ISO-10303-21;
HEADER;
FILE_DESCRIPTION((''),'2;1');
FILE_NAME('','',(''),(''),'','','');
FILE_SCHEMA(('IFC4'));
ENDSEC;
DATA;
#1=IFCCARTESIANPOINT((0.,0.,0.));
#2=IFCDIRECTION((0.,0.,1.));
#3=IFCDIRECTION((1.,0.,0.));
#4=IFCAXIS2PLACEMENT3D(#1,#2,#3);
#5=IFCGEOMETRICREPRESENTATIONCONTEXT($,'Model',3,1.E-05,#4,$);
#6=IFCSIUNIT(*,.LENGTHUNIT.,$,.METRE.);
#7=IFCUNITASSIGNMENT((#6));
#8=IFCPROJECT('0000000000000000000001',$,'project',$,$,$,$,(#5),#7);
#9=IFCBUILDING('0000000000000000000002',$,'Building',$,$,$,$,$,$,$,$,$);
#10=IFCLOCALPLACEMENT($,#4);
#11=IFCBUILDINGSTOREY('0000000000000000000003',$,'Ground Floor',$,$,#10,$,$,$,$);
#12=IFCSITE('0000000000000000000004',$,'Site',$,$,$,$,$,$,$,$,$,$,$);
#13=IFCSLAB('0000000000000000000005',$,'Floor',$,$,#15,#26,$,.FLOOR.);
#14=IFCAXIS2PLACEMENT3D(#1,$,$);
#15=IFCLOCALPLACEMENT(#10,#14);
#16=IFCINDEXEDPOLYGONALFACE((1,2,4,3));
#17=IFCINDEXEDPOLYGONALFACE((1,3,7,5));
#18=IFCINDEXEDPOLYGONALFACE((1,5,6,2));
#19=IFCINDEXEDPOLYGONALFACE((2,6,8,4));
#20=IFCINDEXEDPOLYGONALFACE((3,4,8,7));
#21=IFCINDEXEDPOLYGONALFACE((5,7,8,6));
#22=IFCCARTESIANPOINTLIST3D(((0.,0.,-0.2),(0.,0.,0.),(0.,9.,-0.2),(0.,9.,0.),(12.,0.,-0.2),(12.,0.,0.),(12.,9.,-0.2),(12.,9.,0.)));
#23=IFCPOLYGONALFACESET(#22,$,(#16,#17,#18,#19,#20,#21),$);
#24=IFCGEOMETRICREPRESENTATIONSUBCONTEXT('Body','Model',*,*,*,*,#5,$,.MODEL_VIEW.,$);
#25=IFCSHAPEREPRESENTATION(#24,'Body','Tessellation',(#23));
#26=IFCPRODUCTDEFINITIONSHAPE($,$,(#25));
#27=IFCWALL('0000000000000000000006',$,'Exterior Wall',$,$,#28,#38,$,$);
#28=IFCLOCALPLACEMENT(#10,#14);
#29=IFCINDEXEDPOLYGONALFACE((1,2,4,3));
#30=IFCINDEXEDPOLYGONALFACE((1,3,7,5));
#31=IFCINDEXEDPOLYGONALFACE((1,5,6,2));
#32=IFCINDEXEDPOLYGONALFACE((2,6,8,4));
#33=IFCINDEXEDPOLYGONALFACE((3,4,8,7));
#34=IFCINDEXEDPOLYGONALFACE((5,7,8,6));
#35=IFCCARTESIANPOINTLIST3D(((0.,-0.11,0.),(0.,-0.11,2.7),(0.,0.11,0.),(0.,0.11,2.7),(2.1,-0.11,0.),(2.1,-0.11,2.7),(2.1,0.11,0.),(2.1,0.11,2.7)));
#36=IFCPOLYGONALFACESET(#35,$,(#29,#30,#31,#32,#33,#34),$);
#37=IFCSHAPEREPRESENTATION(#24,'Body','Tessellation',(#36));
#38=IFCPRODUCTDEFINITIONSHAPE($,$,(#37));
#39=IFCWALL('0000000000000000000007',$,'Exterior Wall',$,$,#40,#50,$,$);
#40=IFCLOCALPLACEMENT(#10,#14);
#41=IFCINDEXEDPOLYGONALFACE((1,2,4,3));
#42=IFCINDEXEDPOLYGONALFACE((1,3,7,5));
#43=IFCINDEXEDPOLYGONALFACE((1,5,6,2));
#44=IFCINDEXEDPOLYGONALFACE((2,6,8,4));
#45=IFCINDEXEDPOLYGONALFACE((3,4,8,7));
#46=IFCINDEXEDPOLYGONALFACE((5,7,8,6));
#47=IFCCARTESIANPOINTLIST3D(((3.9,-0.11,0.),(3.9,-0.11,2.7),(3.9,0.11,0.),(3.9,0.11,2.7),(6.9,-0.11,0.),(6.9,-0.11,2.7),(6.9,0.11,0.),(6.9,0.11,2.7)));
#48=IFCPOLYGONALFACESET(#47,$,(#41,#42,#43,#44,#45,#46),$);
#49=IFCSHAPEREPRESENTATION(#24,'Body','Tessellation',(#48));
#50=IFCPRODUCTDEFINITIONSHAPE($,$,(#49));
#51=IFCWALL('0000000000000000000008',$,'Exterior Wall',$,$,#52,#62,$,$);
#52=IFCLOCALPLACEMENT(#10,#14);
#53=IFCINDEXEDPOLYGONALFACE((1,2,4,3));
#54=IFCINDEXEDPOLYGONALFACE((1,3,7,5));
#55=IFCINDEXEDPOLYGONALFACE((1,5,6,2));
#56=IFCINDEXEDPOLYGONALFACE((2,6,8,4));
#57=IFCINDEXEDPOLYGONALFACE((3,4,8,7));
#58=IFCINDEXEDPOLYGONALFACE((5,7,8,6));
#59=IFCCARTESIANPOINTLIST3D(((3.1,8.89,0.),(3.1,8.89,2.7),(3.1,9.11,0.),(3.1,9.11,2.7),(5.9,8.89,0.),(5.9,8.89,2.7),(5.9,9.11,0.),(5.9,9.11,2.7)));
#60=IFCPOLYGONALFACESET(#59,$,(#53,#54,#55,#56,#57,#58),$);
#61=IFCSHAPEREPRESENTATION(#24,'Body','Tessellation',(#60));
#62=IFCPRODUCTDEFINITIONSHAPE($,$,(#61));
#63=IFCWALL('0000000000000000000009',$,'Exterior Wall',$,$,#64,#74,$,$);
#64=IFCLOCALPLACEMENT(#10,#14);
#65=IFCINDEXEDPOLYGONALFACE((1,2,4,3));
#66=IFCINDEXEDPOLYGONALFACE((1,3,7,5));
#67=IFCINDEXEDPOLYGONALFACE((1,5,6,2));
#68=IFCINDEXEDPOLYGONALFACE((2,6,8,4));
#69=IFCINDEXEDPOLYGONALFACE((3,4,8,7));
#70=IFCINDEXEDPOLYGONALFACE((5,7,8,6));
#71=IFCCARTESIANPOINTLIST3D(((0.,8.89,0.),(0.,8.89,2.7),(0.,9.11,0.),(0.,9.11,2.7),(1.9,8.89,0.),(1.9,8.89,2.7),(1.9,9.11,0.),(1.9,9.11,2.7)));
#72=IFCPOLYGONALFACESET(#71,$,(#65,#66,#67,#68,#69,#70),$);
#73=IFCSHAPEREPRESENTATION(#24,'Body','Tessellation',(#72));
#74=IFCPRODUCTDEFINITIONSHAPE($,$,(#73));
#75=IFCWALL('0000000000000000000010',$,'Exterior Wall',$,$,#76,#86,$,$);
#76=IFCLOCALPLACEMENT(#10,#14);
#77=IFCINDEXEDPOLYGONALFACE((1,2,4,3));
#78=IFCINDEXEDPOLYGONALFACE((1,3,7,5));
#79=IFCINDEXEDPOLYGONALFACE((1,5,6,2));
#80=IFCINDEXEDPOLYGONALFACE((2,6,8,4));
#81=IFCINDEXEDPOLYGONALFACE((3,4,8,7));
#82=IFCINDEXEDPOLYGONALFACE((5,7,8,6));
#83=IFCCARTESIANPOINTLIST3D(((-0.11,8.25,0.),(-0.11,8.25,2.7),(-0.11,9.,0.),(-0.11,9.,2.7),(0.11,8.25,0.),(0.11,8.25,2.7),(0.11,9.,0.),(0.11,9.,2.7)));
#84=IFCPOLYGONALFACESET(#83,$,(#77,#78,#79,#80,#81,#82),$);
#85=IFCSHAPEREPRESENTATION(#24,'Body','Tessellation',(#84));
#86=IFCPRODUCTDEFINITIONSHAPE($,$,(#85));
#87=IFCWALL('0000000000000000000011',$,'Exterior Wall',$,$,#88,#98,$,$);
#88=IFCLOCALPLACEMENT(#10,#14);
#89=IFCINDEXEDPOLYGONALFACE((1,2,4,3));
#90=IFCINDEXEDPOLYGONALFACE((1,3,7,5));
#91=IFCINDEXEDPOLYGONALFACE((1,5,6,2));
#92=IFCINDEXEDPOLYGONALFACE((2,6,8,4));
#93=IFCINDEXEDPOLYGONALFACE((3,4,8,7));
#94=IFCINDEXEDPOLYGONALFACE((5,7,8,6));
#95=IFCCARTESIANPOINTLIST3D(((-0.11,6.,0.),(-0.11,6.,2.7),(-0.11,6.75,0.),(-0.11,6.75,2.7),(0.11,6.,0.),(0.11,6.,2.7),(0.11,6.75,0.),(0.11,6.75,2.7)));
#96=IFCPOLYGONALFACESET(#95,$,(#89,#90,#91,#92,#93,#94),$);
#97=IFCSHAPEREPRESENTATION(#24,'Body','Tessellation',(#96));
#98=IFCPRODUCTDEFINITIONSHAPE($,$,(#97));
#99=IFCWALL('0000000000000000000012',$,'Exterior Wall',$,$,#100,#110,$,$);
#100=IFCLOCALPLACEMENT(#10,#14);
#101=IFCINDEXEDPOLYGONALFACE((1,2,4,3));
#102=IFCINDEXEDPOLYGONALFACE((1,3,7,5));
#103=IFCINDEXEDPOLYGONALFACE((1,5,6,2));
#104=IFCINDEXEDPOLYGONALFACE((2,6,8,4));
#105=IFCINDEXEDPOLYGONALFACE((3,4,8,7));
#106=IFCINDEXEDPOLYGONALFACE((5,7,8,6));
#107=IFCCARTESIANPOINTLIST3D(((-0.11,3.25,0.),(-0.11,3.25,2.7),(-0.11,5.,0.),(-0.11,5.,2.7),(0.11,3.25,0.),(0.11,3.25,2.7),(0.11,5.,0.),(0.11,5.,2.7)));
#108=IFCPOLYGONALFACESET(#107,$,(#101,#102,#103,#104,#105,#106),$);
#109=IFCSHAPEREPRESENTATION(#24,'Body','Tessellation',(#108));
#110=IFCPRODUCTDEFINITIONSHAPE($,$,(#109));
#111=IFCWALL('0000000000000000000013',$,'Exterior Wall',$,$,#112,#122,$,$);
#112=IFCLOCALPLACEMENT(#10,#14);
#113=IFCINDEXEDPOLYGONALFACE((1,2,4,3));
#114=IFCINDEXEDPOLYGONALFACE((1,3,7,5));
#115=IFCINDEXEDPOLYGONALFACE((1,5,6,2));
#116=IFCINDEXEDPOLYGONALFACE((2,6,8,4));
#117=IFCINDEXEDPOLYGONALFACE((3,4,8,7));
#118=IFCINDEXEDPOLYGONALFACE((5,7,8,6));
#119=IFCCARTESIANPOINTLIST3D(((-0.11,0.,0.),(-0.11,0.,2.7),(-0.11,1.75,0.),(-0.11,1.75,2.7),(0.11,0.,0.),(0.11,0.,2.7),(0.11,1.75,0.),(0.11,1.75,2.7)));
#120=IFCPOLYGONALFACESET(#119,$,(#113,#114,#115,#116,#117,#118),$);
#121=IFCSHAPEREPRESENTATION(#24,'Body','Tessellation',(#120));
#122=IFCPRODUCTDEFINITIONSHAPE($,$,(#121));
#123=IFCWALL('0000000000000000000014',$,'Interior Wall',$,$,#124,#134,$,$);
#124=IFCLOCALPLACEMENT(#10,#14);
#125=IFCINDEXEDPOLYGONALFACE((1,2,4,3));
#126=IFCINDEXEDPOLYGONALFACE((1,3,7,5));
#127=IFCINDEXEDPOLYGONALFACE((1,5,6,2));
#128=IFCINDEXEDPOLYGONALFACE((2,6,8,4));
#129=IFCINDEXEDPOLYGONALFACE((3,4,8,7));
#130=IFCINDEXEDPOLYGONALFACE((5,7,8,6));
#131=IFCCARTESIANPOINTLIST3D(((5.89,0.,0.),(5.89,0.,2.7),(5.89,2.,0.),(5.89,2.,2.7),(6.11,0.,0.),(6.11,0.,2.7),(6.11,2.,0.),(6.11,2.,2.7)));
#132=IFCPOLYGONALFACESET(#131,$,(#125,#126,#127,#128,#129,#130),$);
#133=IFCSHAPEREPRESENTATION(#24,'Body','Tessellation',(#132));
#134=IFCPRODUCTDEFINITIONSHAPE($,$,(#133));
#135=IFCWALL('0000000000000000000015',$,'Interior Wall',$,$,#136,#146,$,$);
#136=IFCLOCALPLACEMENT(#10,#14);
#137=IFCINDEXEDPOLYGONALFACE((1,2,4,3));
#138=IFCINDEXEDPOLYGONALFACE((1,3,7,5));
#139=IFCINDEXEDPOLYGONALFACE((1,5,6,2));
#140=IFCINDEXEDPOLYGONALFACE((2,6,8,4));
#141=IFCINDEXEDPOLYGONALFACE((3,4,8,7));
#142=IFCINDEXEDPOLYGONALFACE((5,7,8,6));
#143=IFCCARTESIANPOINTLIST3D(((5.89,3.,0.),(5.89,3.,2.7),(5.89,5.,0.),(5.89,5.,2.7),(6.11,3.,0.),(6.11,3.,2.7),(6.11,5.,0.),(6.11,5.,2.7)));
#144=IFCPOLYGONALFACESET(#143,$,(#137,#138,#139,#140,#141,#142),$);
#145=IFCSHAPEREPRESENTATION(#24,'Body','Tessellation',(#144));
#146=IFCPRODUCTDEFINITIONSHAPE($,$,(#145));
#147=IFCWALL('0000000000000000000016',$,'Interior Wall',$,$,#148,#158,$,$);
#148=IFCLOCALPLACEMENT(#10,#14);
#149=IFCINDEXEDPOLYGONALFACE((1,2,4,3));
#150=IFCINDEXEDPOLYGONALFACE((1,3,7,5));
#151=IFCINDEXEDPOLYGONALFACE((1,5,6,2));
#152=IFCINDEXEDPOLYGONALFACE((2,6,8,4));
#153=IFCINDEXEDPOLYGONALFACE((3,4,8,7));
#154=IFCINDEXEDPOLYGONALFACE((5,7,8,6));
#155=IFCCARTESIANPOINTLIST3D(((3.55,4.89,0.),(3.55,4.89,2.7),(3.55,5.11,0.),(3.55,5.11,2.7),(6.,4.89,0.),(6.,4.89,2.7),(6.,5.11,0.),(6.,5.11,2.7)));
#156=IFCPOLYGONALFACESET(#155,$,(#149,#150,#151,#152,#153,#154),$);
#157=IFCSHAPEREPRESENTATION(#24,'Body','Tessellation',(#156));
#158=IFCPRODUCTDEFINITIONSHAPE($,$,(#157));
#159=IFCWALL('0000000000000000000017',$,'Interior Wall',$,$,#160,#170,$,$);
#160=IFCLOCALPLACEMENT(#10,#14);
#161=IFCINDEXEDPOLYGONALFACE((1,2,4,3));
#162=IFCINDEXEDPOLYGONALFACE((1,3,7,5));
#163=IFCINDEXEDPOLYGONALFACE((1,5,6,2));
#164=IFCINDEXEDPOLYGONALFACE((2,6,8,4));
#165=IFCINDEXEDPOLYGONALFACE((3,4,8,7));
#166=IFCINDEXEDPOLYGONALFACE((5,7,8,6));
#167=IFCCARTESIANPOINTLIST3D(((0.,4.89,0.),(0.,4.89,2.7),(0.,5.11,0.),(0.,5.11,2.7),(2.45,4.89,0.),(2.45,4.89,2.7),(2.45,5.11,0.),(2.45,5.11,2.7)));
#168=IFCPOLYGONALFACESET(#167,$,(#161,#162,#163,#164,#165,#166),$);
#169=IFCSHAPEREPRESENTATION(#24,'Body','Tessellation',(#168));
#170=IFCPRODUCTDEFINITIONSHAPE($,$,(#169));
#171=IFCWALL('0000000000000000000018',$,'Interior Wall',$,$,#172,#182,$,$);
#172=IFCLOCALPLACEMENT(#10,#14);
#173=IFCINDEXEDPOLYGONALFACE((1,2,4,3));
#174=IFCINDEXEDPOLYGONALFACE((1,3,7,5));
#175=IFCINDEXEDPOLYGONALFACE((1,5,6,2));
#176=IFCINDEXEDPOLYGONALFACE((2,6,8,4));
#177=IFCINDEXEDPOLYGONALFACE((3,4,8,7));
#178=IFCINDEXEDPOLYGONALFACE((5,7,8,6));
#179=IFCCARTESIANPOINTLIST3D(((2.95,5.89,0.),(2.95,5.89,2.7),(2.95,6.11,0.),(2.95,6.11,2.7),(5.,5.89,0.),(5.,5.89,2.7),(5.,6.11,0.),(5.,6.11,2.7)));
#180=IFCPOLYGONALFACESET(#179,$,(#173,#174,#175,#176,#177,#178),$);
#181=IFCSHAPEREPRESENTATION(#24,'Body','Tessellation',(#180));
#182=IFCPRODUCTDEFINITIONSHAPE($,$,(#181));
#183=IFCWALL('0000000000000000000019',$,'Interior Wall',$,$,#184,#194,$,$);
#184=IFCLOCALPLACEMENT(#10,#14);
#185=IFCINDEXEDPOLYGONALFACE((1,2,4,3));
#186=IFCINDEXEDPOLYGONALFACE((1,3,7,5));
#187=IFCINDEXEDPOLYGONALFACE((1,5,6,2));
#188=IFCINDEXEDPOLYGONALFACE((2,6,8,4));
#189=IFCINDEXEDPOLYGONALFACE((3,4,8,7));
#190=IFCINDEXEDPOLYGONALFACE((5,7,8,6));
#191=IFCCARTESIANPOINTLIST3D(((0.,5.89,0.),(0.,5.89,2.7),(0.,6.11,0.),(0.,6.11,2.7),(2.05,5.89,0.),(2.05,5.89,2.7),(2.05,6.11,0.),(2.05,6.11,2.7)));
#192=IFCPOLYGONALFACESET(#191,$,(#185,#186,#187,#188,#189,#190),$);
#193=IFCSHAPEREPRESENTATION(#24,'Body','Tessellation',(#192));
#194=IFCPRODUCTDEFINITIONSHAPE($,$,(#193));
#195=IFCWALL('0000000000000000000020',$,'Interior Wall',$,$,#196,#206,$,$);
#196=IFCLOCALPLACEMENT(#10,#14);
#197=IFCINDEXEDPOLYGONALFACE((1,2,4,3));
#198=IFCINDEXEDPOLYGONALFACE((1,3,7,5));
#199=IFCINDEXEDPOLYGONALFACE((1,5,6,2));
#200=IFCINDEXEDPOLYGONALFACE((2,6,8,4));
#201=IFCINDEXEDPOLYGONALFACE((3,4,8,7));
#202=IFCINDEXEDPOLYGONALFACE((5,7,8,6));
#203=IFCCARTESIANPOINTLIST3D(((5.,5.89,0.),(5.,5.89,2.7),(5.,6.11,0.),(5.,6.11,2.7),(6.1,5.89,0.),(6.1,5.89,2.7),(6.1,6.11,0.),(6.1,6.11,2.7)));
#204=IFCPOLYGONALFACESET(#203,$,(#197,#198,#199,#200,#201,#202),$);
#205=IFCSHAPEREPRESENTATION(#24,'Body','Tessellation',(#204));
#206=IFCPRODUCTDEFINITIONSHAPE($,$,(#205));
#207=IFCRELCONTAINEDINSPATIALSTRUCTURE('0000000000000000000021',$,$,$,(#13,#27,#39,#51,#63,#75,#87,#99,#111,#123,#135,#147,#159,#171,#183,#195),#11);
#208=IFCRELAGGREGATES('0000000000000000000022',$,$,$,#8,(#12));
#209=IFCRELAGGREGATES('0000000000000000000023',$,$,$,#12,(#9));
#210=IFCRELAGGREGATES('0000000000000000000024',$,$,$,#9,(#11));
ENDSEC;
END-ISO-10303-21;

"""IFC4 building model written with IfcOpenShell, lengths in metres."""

from ifc_helpers import new_model, si_unit, frame, origin_with_axes, place, context, subcontext, project, spatial, indexed_curve, outline, extrude, element, save


model = new_model("IFC4")

# Units and contexts
model_context = context("Model", 3, precision=1e-05, world=origin_with_axes())
body_context = subcontext(model_context, "Body", "Model", "MODEL_VIEW")
ifc_project = project(units=[si_unit("LENGTHUNIT", "METRE")], contexts=[model_context])

# Site, building, storey
site = spatial("IfcSite", under=ifc_project, Name="Site")
building = spatial("IfcBuilding", under=site, Name="Building")
storey_placement = place(None, origin_with_axes())
storey = spatial("IfcBuildingStorey", under=building, at=storey_placement, Name="Ground Floor")

# Slab
slab_placement = place(storey_placement, frame((0.0, 0.0, -0.2), z_axis=(0.0, 0.0, 1.0), x_axis=(1.0, 0.0, 0.0)))
element("IfcSlab", 1, at=slab_placement, inside=storey, Name="Floor", PredefinedType="FLOOR", context=body_context, shape_type="SweptSolid", body=[
    extrude(outline(indexed_curve([(0.0, 0.0), (12.0, 0.0), (12.0, 9.0), (0.0, 9.0)])), None, (0.0, 0.0, 1.0), 0.2),
])

# Walls
wall_1_placement = place(storey_placement, origin_with_axes())
element("IfcWall", 2, at=wall_1_placement, inside=storey, Name="Exterior Wall", context=body_context, shape_type="SweptSolid", body=[
    extrude(outline(indexed_curve([(0.0, 0.0), (0.0, 0.22), (2.1, 0.22), (2.1, 0.0), (0.0, 0.0)], self_intersect=False)), frame((0.0, -0.11, 0.0), z_axis=(0.0, 0.0, 1.0), x_axis=(1.0, 0.0, 0.0)), (0.0, 0.0, 1.0), 2.7),
])
wall_2_placement = place(storey_placement, frame((3.9, 0.0, 0.0), z_axis=(0.0, 0.0, 1.0), x_axis=(1.0, 0.0, 0.0)))
element("IfcWall", 3, at=wall_2_placement, inside=storey, Name="Exterior Wall", context=body_context, shape_type="SweptSolid", body=[
    extrude(outline(indexed_curve([(0.0, 0.0), (0.0, 0.22), (3.0, 0.22), (3.0, 0.0), (0.0, 0.0)], self_intersect=False)), frame((0.0, -0.11, 0.0), z_axis=(0.0, 0.0, 1.0), x_axis=(1.0, 0.0, 0.0)), (0.0, 0.0, 1.0), 2.7),
])
wall_3_placement = place(storey_placement, frame((5.9, 9.0, 0.0), z_axis=(0.0, 0.0, 1.0), x_axis=(-1.0, 0.0, 0.0)))
element("IfcWall", 4, at=wall_3_placement, inside=storey, Name="Exterior Wall", context=body_context, shape_type="SweptSolid", body=[
    extrude(outline(indexed_curve([(0.0, 0.0), (0.0, 0.22), (2.8, 0.22), (2.8, 0.0), (0.0, 0.0)], self_intersect=False)), frame((0.0, -0.11, 0.0), z_axis=(0.0, 0.0, 1.0), x_axis=(1.0, 0.0, 0.0)), (0.0, 0.0, 1.0), 2.7),
])
wall_4_placement = place(storey_placement, frame((1.9, 9.0, 0.0), z_axis=(0.0, 0.0, 1.0), x_axis=(-1.0, 0.0, 0.0)))
element("IfcWall", 5, at=wall_4_placement, inside=storey, Name="Exterior Wall", context=body_context, shape_type="SweptSolid", body=[
    extrude(outline(indexed_curve([(0.0, 0.0), (0.0, 0.22), (1.9, 0.22), (1.9, 0.0), (0.0, 0.0)], self_intersect=False)), frame((0.0, -0.11, 0.0), z_axis=(0.0, 0.0, 1.0), x_axis=(1.0, 0.0, 0.0)), (0.0, 0.0, 1.0), 2.7),
])
for number, where, z_axis, x_axis, name in (
    (6, (0.0, 9.0, 0.0), (0.0, 0.0, 1.0), (0.0, -1.0, 0.0), "Exterior Wall"),
    (7, (0.0, 6.75, 0.0), (0.0, 0.0, 1.0), (0.0, -1.0, 0.0), "Exterior Wall"),
):
    element("IfcWall", number, at=place(storey_placement, frame(where, z_axis=z_axis, x_axis=x_axis)), inside=storey, Name=name, context=body_context, shape_type="SweptSolid", body=[
        extrude(outline(indexed_curve([(0.0, 0.0), (0.0, 0.22), (0.75, 0.22), (0.75, 0.0), (0.0, 0.0)], self_intersect=False)), frame((0.0, -0.11, 0.0), z_axis=(0.0, 0.0, 1.0), x_axis=(1.0, 0.0, 0.0)), (0.0, 0.0, 1.0), 2.7),
    ])
for number, where, z_axis, x_axis, name in (
    (8, (0.0, 5.0, 0.0), (0.0, 0.0, 1.0), (0.0, -1.0, 0.0), "Exterior Wall"),
    (9, (0.0, 1.75, 0.0), (0.0, 0.0, 1.0), (0.0, -1.0, 0.0), "Exterior Wall"),
):
    element("IfcWall", number, at=place(storey_placement, frame(where, z_axis=z_axis, x_axis=x_axis)), inside=storey, Name=name, context=body_context, shape_type="SweptSolid", body=[
        extrude(outline(indexed_curve([(0.0, 0.0), (0.0, 0.22), (1.75, 0.22), (1.75, 0.0), (0.0, 0.0)], self_intersect=False)), frame((0.0, -0.11, 0.0), z_axis=(0.0, 0.0, 1.0), x_axis=(1.0, 0.0, 0.0)), (0.0, 0.0, 1.0), 2.7),
    ])
for number, where, z_axis, x_axis, name in (
    (10, (6.0, 0.0, 0.0), (0.0, 0.0, 1.0), (0.0, 1.0, 0.0), "Interior Wall"),
    (11, (6.0, 3.0, 0.0), (0.0, 0.0, 1.0), (0.0, 1.0, 0.0), "Interior Wall"),
):
    element("IfcWall", number, at=place(storey_placement, frame(where, z_axis=z_axis, x_axis=x_axis)), inside=storey, Name=name, context=body_context, shape_type="SweptSolid", body=[
        extrude(outline(indexed_curve([(0.0, 0.0), (0.0, 0.22), (2.0, 0.22), (2.0, 0.0), (0.0, 0.0)], self_intersect=False)), frame((0.0, -0.11, 0.0), z_axis=(0.0, 0.0, 1.0), x_axis=(1.0, 0.0, 0.0)), (0.0, 0.0, 1.0), 2.7),
    ])
for number, where, z_axis, x_axis, name in (
    (12, (6.0, 5.0, 0.0), (0.0, 0.0, 1.0), (-1.0, 0.0, 0.0), "Interior Wall"),
    (13, (2.45, 5.0, 0.0), (0.0, 0.0, 1.0), (-1.0, 0.0, 0.0), "Interior Wall"),
):
    element("IfcWall", number, at=place(storey_placement, frame(where, z_axis=z_axis, x_axis=x_axis)), inside=storey, Name=name, context=body_context, shape_type="SweptSolid", body=[
        extrude(outline(indexed_curve([(0.0, 0.0), (0.0, 0.22), (2.45, 0.22), (2.45, 0.0), (0.0, 0.0)], self_intersect=False)), frame((0.0, -0.11, 0.0), z_axis=(0.0, 0.0, 1.0), x_axis=(1.0, 0.0, 0.0)), (0.0, 0.0, 1.0), 2.7),
    ])
for number, where, z_axis, x_axis, name in (
    (14, (5.0, 6.0, 0.0), (0.0, 0.0, 1.0), (-1.0, 0.0, 0.0), "Interior Wall"),
    (15, (2.05, 6.0, 0.0), (0.0, 0.0, 1.0), (-1.0, 0.0, 0.0), "Interior Wall"),
):
    element("IfcWall", number, at=place(storey_placement, frame(where, z_axis=z_axis, x_axis=x_axis)), inside=storey, Name=name, context=body_context, shape_type="SweptSolid", body=[
        extrude(outline(indexed_curve([(0.0, 0.0), (0.0, 0.22), (2.05, 0.22), (2.05, 0.0), (0.0, 0.0)], self_intersect=False)), frame((0.0, -0.11, 0.0), z_axis=(0.0, 0.0, 1.0), x_axis=(1.0, 0.0, 0.0)), (0.0, 0.0, 1.0), 2.7),
    ])
wall_5_placement = place(storey_placement, frame((6.1, 6.0, 0.0), z_axis=(0.0, 0.0, 1.0), x_axis=(-1.0, 0.0, 0.0)))
element("IfcWall", 16, at=wall_5_placement, inside=storey, Name="Interior Wall", context=body_context, shape_type="SweptSolid", body=[
    extrude(outline(indexed_curve([(0.0, 0.0), (0.0, 0.22), (1.1, 0.22), (1.1, 0.0), (0.0, 0.0)], self_intersect=False)), frame((0.0, -0.11, 0.0), z_axis=(0.0, 0.0, 1.0), x_axis=(1.0, 0.0, 0.0)), (0.0, 0.0, 1.0), 2.7),
])

save(model, "model.ifc")
